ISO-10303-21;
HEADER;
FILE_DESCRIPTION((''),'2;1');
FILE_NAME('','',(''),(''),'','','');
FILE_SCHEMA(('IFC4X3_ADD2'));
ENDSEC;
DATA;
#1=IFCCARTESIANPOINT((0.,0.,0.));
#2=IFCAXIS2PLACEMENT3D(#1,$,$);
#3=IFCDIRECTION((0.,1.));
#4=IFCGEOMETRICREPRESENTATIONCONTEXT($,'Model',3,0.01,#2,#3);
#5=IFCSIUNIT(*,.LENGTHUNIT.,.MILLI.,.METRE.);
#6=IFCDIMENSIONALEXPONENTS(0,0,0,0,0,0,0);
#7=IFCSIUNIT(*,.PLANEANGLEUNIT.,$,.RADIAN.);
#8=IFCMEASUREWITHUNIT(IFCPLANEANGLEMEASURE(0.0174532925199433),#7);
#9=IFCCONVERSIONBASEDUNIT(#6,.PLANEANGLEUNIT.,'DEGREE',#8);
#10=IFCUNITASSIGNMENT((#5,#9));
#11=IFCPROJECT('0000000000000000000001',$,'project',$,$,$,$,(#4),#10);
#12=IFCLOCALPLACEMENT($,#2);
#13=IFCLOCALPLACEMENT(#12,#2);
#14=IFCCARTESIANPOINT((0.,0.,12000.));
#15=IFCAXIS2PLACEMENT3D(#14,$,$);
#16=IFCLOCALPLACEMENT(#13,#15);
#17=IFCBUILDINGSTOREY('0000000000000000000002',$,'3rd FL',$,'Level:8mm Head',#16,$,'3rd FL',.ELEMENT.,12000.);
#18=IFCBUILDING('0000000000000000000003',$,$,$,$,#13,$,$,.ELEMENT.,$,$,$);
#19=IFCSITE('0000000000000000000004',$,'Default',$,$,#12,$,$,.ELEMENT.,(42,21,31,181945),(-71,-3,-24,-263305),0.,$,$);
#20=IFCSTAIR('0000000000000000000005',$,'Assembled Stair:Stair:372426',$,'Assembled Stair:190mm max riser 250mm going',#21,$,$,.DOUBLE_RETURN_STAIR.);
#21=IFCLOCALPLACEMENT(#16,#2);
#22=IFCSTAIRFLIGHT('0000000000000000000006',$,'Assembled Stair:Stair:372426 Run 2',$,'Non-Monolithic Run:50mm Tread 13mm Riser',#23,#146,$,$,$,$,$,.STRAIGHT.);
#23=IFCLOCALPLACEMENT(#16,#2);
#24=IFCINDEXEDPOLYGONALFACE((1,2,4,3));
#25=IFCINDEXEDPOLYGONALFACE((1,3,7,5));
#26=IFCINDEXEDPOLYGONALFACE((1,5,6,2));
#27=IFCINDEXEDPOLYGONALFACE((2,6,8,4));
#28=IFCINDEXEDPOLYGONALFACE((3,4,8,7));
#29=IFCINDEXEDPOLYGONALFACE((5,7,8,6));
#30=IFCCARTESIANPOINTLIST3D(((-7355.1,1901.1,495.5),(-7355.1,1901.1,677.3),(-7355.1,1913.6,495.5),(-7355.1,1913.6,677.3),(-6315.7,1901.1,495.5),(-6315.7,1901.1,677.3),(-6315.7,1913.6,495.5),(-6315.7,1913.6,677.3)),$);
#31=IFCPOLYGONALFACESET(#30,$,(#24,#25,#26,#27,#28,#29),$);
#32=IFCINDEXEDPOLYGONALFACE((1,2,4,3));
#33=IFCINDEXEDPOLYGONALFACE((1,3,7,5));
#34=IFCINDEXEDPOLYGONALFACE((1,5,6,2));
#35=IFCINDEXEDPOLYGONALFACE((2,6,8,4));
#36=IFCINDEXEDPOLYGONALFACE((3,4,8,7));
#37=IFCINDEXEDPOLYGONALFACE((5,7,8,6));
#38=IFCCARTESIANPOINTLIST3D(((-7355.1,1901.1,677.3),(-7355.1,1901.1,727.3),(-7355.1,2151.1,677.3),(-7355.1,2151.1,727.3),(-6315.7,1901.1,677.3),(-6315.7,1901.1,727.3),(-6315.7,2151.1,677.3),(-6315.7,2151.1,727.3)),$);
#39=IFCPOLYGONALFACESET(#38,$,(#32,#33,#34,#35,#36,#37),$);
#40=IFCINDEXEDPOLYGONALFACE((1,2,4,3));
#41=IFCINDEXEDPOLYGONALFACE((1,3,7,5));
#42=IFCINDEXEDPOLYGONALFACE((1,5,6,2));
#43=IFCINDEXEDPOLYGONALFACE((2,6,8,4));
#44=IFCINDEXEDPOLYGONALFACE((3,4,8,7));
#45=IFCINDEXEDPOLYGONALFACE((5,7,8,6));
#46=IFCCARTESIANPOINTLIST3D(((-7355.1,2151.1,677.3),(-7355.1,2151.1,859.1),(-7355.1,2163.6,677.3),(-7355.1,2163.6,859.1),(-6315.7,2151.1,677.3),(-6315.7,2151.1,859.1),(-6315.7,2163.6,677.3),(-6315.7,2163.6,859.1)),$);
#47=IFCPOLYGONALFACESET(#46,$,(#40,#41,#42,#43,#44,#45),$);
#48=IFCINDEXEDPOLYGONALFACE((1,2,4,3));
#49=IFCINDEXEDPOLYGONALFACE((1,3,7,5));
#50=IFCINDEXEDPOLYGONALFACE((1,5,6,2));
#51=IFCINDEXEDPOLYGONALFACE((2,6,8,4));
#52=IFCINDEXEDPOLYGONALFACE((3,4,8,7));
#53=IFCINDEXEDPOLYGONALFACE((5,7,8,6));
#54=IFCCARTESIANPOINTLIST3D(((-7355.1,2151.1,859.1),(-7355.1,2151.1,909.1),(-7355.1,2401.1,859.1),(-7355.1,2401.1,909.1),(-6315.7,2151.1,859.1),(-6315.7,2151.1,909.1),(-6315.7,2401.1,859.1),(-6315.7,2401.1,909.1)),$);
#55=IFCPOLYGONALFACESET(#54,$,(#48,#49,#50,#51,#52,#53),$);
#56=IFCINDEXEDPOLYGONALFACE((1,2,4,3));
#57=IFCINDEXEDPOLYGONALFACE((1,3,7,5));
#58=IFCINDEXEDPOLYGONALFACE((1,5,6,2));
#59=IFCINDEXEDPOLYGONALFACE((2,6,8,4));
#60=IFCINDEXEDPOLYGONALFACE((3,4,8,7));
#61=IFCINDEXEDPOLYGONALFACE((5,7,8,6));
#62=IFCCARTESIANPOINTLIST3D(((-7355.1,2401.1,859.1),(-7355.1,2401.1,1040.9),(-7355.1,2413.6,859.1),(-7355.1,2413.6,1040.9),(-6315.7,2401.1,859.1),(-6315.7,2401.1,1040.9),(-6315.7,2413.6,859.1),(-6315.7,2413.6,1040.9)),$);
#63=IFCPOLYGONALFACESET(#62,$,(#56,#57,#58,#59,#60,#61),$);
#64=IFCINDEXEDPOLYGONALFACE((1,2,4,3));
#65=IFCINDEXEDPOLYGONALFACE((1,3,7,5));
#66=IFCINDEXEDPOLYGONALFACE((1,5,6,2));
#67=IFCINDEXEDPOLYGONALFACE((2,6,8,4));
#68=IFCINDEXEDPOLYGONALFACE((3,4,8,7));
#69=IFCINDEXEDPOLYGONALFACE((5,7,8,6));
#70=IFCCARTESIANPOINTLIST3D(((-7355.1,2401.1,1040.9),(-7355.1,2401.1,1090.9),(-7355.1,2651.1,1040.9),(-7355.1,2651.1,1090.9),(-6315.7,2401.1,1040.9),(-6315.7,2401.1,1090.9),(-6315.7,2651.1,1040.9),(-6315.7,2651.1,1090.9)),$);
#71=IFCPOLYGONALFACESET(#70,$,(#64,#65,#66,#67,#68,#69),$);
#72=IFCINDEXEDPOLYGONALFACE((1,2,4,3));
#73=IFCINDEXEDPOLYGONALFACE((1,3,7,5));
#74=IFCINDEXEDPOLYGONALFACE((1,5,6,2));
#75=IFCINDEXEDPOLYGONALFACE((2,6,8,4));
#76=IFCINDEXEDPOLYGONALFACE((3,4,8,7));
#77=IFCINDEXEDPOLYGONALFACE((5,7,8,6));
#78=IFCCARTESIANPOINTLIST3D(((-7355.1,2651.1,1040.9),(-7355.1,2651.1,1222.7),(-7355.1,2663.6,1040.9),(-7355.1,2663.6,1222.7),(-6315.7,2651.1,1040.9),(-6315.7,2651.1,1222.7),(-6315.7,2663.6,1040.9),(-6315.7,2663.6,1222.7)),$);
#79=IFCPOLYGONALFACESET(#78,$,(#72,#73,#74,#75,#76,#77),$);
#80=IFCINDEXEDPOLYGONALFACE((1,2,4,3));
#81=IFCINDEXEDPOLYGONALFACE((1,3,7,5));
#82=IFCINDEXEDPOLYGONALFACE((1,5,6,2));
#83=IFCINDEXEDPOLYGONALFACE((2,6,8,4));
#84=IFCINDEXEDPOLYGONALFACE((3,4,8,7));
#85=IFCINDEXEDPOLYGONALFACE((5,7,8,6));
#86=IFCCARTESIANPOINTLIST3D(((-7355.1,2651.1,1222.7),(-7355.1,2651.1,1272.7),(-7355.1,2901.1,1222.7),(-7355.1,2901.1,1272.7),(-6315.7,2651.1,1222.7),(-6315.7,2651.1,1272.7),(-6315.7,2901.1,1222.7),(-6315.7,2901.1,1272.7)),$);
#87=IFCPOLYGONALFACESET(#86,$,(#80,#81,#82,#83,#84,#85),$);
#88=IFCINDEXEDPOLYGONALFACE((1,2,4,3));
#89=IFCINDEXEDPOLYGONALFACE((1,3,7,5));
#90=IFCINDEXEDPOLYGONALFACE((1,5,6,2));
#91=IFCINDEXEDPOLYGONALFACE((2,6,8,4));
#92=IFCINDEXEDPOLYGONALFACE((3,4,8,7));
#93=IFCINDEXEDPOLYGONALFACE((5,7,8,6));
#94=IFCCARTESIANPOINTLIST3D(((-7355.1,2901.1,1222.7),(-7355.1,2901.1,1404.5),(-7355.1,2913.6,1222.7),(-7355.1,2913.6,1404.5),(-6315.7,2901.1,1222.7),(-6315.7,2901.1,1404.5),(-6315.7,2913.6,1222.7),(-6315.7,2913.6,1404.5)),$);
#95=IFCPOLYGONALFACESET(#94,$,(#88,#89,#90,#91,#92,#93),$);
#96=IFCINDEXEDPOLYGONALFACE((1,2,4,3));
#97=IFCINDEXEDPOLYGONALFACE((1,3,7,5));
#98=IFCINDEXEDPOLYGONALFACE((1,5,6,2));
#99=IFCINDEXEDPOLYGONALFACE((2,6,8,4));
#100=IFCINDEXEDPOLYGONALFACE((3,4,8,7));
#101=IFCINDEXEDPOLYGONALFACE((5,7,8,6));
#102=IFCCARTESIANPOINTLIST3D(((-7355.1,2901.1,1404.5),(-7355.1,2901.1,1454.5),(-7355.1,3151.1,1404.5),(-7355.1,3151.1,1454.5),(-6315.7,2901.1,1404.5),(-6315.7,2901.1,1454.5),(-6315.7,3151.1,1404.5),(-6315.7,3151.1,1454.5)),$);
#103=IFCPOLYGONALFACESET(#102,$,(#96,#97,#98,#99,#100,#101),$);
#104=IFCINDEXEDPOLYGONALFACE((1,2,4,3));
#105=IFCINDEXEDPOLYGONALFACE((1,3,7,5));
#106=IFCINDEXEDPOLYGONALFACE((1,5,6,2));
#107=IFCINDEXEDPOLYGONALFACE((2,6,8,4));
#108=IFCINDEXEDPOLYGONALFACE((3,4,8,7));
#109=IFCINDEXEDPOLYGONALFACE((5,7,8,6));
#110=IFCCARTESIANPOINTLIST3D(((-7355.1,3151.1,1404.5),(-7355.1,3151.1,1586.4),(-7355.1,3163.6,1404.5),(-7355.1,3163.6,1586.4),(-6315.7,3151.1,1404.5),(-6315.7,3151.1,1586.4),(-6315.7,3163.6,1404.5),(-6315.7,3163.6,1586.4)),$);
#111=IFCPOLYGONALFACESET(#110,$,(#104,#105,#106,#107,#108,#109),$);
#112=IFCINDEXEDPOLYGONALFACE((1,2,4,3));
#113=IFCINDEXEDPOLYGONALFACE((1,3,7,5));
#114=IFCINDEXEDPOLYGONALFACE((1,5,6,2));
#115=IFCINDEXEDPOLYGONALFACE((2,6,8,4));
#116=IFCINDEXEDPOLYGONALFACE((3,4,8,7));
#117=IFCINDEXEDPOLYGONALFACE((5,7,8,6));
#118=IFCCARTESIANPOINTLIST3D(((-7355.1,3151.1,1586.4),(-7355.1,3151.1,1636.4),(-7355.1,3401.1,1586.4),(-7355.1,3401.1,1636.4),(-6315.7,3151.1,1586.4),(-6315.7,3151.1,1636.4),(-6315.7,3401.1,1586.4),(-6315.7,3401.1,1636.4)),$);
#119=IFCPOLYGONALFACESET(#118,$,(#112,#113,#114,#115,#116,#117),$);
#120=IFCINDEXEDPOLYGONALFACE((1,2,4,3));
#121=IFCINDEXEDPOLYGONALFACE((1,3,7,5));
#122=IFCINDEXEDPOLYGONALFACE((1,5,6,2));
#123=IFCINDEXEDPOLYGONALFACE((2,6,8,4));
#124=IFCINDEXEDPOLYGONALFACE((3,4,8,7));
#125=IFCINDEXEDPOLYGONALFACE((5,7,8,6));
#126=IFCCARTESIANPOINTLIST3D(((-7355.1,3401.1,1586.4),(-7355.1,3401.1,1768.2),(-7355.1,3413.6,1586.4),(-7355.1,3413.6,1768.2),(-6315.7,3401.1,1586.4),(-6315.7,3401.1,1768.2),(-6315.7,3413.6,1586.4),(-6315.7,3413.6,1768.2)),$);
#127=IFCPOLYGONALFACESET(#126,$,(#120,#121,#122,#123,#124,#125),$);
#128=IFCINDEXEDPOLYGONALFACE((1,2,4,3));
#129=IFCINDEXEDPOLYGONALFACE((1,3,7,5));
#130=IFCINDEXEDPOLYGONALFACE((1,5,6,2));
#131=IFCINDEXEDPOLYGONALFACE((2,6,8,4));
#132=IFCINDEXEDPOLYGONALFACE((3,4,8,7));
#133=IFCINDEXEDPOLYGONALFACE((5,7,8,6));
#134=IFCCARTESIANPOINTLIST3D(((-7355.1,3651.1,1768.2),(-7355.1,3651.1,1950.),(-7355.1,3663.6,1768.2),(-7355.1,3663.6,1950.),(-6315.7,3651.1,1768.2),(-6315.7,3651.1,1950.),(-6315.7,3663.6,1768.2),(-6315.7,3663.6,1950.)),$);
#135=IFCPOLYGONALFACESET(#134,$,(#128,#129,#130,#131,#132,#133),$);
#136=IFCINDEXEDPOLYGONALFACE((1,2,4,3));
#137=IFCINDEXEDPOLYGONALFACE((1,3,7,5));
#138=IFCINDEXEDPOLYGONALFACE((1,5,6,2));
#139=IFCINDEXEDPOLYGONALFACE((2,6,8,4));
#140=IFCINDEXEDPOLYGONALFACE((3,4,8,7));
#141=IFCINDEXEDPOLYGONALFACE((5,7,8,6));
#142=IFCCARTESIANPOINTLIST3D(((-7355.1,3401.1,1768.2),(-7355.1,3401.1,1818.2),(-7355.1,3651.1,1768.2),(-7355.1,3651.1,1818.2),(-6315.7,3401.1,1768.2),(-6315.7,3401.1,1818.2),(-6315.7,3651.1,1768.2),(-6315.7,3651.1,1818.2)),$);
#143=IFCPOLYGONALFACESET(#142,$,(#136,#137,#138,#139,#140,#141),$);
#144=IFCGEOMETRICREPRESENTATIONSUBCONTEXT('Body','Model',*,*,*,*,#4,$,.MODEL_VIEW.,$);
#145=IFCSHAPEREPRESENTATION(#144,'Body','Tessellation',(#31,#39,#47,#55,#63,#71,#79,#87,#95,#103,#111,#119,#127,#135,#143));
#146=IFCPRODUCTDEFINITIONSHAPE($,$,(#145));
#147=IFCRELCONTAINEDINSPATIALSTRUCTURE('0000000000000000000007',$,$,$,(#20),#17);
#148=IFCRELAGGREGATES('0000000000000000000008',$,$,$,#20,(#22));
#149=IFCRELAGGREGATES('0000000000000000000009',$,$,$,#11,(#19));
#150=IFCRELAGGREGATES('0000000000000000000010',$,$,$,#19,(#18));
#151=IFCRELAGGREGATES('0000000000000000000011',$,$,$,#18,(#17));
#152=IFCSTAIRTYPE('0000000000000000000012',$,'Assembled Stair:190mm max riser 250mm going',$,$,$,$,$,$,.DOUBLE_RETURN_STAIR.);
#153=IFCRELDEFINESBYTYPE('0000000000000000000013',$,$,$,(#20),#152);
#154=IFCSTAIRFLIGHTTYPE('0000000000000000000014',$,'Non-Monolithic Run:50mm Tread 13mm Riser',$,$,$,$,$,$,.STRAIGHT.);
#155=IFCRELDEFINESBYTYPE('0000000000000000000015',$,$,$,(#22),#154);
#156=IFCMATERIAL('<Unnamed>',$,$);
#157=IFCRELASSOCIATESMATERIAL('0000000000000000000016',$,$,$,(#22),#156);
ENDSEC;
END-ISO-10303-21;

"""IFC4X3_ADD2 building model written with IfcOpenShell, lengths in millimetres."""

from ifc_helpers import new_model, entity, si_unit, converted_unit, direction, frame, frame_2d, origin, origin_2d_with_axis, place, context, subcontext, project, spatial, rectangle, extrude, material, type_object, element, aggregate, save


model = new_model("IFC4X3_ADD2")

# Units and contexts
model_context = context("Model", 3, precision=0.01, world=origin(), true_north=direction((0.0, 1.0)))
body_context = subcontext(model_context, "Body", "Model", "MODEL_VIEW")
ifc_project = project(units=[si_unit("LENGTHUNIT", "METRE", prefix="MILLI"), converted_unit("PLANEANGLEUNIT", "DEGREE", entity("IfcPlaneAngleMeasure", 0.0174532925199433), si_unit("PLANEANGLEUNIT", "RADIAN"), dimensions=[0, 0, 0, 0, 0, 0, 0])], contexts=[model_context])

# Site, building, storey
site_placement = place(None, origin())
site = spatial("IfcSite", under=ifc_project, at=site_placement, Name="Default", CompositionType="ELEMENT", RefLatitude=(42, 21, 31, 181945), RefLongitude=(-71, -3, -24, -263305), RefElevation=0.0)
building_placement = place(site_placement, origin())
building = spatial("IfcBuilding", under=site, at=building_placement, CompositionType="ELEMENT")
storey_placement = place(building_placement, frame((0.0, 0.0, 12000.0)))
storey = spatial("IfcBuildingStorey", under=building, at=storey_placement, Name="3rd FL", ObjectType="Level:8mm Head", LongName="3rd FL", CompositionType="ELEMENT", Elevation=12000.0)

# Stair
stair_type = type_object("IfcStairType", Name="Assembled Stair:190mm max riser 250mm going", PredefinedType="DOUBLE_RETURN_STAIR")
stair_placement = place(storey_placement, origin())
stair = element("IfcStair", 1, at=stair_placement, inside=storey, type_object=stair_type, Name="Assembled Stair:Stair:372426", ObjectType="Assembled Stair:190mm max riser 250mm going", PredefinedType="DOUBLE_RETURN_STAIR")
ifc_material_1 = material(Name="<Unnamed>")

# Stair flight
stair_flight_type = type_object("IfcStairFlightType", Name="Non-Monolithic Run:50mm Tread 13mm Riser", PredefinedType="STRAIGHT")
stair_flight_1_placement = place(stair_placement, frame((-7355.1, 1901.1, 0.0)))
stair_flight_1 = element("IfcStairFlight", 2, at=stair_flight_1_placement, type_object=stair_flight_type, material=ifc_material_1, Name="Assembled Stair:Stair:372426 Run 2", ObjectType="Non-Monolithic Run:50mm Tread 13mm Riser", PredefinedType="STRAIGHT", context=body_context, shape_type="SweptSolid", body=[
    extrude(rectangle(XDim=1039.4, YDim=12.5, at=frame_2d((0.0, 0.0), x_axis=(1.0, 0.0))), frame((519.7, 6.2, 495.5), z_axis=(0.0, 0.0, 1.0), x_axis=(-1.0, 0.0, 0.0)), (0.0, 0.0, 1.0), 181.8),
    extrude(rectangle(XDim=250.0, YDim=1039.4, at=frame_2d((0.0, 0.0), x_axis=(1.0, 0.0))), frame((519.7, 125.0, 677.3), z_axis=(0.0, 0.0, 1.0), x_axis=(0.0, -1.0, 0.0)), (0.0, 0.0, 1.0), 50.0),
    extrude(rectangle(XDim=1039.4, YDim=12.5, at=frame_2d((0.0, 0.0), x_axis=(1.0, 0.0))), frame((519.7, 256.2, 677.3), z_axis=(0.0, 0.0, 1.0), x_axis=(-1.0, 0.0, 0.0)), (0.0, 0.0, 1.0), 181.8),
    extrude(rectangle(XDim=250.0, YDim=1039.4, at=frame_2d((0.0, 0.0), x_axis=(1.0, 0.0))), frame((519.7, 375.0, 859.1), z_axis=(0.0, 0.0, 1.0), x_axis=(0.0, -1.0, 0.0)), (0.0, 0.0, 1.0), 50.0),
    extrude(rectangle(XDim=1039.4, YDim=12.5, at=frame_2d((0.0, 0.0), x_axis=(1.0, 0.0))), frame((519.7, 506.2, 859.1), z_axis=(0.0, 0.0, 1.0), x_axis=(-1.0, 0.0, 0.0)), (0.0, 0.0, 1.0), 181.8),
    extrude(rectangle(XDim=250.0, YDim=1039.4, at=frame_2d((0.0, 0.0), x_axis=(1.0, 0.0))), frame((519.7, 625.0, 1040.9), z_axis=(0.0, 0.0, 1.0), x_axis=(0.0, -1.0, 0.0)), (0.0, 0.0, 1.0), 50.0),
    extrude(rectangle(XDim=1039.4, YDim=12.5, at=frame_2d((0.0, 0.0), x_axis=(1.0, 0.0))), frame((519.7, 756.3, 1040.9), z_axis=(0.0, 0.0, 1.0), x_axis=(-1.0, 0.0, 0.0)), (0.0, 0.0, 1.0), 181.8),
    extrude(rectangle(XDim=250.0, YDim=1039.4, at=frame_2d((0.0, 0.0), x_axis=(1.0, 0.0))), frame((519.7, 875.0, 1222.7), z_axis=(0.0, 0.0, 1.0), x_axis=(0.0, -1.0, 0.0)), (0.0, 0.0, 1.0), 50.0),
    extrude(rectangle(XDim=1039.4, YDim=12.5, at=origin_2d_with_axis()), frame((519.7, 1006.2, 1222.7), z_axis=(0.0, 0.0, 1.0), x_axis=(-1.0, 0.0, 0.0)), (0.0, 0.0, 1.0), 181.8),
    extrude(rectangle(XDim=250.0, YDim=1039.4, at=frame_2d((0.0, 0.0), x_axis=(1.0, 0.0))), frame((519.7, 1125.0, 1404.5), z_axis=(0.0, 0.0, 1.0), x_axis=(0.0, -1.0, 0.0)), (0.0, 0.0, 1.0), 50.0),
    extrude(rectangle(XDim=1039.4, YDim=12.5, at=origin_2d_with_axis()), frame((519.7, 1256.2, 1404.5), z_axis=(0.0, 0.0, 1.0), x_axis=(-1.0, 0.0, 0.0)), (0.0, 0.0, 1.0), 181.8),
    extrude(rectangle(XDim=250.0, YDim=1039.4, at=frame_2d((0.0, 0.0), x_axis=(1.0, 0.0))), frame((519.7, 1375.0, 1586.4), z_axis=(0.0, 0.0, 1.0), x_axis=(0.0, -1.0, 0.0)), (0.0, 0.0, 1.0), 50.0),
    extrude(rectangle(XDim=1039.4, YDim=12.5, at=origin_2d_with_axis()), frame((519.7, 1506.2, 1586.4), z_axis=(0.0, 0.0, 1.0), x_axis=(-1.0, 0.0, 0.0)), (0.0, 0.0, 1.0), 181.8),
    extrude(rectangle(XDim=1039.4, YDim=12.5, at=frame_2d((0.0, 0.0), x_axis=(1.0, 0.0))), frame((519.7, 1756.2, 1768.2), z_axis=(0.0, 0.0, 1.0), x_axis=(-1.0, 0.0, 0.0)), (0.0, 0.0, 1.0), 181.8),
    extrude(rectangle(XDim=250.0, YDim=1039.4, at=frame_2d((0.0, 0.0), x_axis=(1.0, 0.0))), frame((519.7, 1625.0, 1768.2), z_axis=(0.0, 0.0, 1.0), x_axis=(0.0, -1.0, 0.0)), (0.0, 0.0, 1.0), 50.0),
])
aggregate(stair, [stair_flight_1])

save(model, "model.ifc")
